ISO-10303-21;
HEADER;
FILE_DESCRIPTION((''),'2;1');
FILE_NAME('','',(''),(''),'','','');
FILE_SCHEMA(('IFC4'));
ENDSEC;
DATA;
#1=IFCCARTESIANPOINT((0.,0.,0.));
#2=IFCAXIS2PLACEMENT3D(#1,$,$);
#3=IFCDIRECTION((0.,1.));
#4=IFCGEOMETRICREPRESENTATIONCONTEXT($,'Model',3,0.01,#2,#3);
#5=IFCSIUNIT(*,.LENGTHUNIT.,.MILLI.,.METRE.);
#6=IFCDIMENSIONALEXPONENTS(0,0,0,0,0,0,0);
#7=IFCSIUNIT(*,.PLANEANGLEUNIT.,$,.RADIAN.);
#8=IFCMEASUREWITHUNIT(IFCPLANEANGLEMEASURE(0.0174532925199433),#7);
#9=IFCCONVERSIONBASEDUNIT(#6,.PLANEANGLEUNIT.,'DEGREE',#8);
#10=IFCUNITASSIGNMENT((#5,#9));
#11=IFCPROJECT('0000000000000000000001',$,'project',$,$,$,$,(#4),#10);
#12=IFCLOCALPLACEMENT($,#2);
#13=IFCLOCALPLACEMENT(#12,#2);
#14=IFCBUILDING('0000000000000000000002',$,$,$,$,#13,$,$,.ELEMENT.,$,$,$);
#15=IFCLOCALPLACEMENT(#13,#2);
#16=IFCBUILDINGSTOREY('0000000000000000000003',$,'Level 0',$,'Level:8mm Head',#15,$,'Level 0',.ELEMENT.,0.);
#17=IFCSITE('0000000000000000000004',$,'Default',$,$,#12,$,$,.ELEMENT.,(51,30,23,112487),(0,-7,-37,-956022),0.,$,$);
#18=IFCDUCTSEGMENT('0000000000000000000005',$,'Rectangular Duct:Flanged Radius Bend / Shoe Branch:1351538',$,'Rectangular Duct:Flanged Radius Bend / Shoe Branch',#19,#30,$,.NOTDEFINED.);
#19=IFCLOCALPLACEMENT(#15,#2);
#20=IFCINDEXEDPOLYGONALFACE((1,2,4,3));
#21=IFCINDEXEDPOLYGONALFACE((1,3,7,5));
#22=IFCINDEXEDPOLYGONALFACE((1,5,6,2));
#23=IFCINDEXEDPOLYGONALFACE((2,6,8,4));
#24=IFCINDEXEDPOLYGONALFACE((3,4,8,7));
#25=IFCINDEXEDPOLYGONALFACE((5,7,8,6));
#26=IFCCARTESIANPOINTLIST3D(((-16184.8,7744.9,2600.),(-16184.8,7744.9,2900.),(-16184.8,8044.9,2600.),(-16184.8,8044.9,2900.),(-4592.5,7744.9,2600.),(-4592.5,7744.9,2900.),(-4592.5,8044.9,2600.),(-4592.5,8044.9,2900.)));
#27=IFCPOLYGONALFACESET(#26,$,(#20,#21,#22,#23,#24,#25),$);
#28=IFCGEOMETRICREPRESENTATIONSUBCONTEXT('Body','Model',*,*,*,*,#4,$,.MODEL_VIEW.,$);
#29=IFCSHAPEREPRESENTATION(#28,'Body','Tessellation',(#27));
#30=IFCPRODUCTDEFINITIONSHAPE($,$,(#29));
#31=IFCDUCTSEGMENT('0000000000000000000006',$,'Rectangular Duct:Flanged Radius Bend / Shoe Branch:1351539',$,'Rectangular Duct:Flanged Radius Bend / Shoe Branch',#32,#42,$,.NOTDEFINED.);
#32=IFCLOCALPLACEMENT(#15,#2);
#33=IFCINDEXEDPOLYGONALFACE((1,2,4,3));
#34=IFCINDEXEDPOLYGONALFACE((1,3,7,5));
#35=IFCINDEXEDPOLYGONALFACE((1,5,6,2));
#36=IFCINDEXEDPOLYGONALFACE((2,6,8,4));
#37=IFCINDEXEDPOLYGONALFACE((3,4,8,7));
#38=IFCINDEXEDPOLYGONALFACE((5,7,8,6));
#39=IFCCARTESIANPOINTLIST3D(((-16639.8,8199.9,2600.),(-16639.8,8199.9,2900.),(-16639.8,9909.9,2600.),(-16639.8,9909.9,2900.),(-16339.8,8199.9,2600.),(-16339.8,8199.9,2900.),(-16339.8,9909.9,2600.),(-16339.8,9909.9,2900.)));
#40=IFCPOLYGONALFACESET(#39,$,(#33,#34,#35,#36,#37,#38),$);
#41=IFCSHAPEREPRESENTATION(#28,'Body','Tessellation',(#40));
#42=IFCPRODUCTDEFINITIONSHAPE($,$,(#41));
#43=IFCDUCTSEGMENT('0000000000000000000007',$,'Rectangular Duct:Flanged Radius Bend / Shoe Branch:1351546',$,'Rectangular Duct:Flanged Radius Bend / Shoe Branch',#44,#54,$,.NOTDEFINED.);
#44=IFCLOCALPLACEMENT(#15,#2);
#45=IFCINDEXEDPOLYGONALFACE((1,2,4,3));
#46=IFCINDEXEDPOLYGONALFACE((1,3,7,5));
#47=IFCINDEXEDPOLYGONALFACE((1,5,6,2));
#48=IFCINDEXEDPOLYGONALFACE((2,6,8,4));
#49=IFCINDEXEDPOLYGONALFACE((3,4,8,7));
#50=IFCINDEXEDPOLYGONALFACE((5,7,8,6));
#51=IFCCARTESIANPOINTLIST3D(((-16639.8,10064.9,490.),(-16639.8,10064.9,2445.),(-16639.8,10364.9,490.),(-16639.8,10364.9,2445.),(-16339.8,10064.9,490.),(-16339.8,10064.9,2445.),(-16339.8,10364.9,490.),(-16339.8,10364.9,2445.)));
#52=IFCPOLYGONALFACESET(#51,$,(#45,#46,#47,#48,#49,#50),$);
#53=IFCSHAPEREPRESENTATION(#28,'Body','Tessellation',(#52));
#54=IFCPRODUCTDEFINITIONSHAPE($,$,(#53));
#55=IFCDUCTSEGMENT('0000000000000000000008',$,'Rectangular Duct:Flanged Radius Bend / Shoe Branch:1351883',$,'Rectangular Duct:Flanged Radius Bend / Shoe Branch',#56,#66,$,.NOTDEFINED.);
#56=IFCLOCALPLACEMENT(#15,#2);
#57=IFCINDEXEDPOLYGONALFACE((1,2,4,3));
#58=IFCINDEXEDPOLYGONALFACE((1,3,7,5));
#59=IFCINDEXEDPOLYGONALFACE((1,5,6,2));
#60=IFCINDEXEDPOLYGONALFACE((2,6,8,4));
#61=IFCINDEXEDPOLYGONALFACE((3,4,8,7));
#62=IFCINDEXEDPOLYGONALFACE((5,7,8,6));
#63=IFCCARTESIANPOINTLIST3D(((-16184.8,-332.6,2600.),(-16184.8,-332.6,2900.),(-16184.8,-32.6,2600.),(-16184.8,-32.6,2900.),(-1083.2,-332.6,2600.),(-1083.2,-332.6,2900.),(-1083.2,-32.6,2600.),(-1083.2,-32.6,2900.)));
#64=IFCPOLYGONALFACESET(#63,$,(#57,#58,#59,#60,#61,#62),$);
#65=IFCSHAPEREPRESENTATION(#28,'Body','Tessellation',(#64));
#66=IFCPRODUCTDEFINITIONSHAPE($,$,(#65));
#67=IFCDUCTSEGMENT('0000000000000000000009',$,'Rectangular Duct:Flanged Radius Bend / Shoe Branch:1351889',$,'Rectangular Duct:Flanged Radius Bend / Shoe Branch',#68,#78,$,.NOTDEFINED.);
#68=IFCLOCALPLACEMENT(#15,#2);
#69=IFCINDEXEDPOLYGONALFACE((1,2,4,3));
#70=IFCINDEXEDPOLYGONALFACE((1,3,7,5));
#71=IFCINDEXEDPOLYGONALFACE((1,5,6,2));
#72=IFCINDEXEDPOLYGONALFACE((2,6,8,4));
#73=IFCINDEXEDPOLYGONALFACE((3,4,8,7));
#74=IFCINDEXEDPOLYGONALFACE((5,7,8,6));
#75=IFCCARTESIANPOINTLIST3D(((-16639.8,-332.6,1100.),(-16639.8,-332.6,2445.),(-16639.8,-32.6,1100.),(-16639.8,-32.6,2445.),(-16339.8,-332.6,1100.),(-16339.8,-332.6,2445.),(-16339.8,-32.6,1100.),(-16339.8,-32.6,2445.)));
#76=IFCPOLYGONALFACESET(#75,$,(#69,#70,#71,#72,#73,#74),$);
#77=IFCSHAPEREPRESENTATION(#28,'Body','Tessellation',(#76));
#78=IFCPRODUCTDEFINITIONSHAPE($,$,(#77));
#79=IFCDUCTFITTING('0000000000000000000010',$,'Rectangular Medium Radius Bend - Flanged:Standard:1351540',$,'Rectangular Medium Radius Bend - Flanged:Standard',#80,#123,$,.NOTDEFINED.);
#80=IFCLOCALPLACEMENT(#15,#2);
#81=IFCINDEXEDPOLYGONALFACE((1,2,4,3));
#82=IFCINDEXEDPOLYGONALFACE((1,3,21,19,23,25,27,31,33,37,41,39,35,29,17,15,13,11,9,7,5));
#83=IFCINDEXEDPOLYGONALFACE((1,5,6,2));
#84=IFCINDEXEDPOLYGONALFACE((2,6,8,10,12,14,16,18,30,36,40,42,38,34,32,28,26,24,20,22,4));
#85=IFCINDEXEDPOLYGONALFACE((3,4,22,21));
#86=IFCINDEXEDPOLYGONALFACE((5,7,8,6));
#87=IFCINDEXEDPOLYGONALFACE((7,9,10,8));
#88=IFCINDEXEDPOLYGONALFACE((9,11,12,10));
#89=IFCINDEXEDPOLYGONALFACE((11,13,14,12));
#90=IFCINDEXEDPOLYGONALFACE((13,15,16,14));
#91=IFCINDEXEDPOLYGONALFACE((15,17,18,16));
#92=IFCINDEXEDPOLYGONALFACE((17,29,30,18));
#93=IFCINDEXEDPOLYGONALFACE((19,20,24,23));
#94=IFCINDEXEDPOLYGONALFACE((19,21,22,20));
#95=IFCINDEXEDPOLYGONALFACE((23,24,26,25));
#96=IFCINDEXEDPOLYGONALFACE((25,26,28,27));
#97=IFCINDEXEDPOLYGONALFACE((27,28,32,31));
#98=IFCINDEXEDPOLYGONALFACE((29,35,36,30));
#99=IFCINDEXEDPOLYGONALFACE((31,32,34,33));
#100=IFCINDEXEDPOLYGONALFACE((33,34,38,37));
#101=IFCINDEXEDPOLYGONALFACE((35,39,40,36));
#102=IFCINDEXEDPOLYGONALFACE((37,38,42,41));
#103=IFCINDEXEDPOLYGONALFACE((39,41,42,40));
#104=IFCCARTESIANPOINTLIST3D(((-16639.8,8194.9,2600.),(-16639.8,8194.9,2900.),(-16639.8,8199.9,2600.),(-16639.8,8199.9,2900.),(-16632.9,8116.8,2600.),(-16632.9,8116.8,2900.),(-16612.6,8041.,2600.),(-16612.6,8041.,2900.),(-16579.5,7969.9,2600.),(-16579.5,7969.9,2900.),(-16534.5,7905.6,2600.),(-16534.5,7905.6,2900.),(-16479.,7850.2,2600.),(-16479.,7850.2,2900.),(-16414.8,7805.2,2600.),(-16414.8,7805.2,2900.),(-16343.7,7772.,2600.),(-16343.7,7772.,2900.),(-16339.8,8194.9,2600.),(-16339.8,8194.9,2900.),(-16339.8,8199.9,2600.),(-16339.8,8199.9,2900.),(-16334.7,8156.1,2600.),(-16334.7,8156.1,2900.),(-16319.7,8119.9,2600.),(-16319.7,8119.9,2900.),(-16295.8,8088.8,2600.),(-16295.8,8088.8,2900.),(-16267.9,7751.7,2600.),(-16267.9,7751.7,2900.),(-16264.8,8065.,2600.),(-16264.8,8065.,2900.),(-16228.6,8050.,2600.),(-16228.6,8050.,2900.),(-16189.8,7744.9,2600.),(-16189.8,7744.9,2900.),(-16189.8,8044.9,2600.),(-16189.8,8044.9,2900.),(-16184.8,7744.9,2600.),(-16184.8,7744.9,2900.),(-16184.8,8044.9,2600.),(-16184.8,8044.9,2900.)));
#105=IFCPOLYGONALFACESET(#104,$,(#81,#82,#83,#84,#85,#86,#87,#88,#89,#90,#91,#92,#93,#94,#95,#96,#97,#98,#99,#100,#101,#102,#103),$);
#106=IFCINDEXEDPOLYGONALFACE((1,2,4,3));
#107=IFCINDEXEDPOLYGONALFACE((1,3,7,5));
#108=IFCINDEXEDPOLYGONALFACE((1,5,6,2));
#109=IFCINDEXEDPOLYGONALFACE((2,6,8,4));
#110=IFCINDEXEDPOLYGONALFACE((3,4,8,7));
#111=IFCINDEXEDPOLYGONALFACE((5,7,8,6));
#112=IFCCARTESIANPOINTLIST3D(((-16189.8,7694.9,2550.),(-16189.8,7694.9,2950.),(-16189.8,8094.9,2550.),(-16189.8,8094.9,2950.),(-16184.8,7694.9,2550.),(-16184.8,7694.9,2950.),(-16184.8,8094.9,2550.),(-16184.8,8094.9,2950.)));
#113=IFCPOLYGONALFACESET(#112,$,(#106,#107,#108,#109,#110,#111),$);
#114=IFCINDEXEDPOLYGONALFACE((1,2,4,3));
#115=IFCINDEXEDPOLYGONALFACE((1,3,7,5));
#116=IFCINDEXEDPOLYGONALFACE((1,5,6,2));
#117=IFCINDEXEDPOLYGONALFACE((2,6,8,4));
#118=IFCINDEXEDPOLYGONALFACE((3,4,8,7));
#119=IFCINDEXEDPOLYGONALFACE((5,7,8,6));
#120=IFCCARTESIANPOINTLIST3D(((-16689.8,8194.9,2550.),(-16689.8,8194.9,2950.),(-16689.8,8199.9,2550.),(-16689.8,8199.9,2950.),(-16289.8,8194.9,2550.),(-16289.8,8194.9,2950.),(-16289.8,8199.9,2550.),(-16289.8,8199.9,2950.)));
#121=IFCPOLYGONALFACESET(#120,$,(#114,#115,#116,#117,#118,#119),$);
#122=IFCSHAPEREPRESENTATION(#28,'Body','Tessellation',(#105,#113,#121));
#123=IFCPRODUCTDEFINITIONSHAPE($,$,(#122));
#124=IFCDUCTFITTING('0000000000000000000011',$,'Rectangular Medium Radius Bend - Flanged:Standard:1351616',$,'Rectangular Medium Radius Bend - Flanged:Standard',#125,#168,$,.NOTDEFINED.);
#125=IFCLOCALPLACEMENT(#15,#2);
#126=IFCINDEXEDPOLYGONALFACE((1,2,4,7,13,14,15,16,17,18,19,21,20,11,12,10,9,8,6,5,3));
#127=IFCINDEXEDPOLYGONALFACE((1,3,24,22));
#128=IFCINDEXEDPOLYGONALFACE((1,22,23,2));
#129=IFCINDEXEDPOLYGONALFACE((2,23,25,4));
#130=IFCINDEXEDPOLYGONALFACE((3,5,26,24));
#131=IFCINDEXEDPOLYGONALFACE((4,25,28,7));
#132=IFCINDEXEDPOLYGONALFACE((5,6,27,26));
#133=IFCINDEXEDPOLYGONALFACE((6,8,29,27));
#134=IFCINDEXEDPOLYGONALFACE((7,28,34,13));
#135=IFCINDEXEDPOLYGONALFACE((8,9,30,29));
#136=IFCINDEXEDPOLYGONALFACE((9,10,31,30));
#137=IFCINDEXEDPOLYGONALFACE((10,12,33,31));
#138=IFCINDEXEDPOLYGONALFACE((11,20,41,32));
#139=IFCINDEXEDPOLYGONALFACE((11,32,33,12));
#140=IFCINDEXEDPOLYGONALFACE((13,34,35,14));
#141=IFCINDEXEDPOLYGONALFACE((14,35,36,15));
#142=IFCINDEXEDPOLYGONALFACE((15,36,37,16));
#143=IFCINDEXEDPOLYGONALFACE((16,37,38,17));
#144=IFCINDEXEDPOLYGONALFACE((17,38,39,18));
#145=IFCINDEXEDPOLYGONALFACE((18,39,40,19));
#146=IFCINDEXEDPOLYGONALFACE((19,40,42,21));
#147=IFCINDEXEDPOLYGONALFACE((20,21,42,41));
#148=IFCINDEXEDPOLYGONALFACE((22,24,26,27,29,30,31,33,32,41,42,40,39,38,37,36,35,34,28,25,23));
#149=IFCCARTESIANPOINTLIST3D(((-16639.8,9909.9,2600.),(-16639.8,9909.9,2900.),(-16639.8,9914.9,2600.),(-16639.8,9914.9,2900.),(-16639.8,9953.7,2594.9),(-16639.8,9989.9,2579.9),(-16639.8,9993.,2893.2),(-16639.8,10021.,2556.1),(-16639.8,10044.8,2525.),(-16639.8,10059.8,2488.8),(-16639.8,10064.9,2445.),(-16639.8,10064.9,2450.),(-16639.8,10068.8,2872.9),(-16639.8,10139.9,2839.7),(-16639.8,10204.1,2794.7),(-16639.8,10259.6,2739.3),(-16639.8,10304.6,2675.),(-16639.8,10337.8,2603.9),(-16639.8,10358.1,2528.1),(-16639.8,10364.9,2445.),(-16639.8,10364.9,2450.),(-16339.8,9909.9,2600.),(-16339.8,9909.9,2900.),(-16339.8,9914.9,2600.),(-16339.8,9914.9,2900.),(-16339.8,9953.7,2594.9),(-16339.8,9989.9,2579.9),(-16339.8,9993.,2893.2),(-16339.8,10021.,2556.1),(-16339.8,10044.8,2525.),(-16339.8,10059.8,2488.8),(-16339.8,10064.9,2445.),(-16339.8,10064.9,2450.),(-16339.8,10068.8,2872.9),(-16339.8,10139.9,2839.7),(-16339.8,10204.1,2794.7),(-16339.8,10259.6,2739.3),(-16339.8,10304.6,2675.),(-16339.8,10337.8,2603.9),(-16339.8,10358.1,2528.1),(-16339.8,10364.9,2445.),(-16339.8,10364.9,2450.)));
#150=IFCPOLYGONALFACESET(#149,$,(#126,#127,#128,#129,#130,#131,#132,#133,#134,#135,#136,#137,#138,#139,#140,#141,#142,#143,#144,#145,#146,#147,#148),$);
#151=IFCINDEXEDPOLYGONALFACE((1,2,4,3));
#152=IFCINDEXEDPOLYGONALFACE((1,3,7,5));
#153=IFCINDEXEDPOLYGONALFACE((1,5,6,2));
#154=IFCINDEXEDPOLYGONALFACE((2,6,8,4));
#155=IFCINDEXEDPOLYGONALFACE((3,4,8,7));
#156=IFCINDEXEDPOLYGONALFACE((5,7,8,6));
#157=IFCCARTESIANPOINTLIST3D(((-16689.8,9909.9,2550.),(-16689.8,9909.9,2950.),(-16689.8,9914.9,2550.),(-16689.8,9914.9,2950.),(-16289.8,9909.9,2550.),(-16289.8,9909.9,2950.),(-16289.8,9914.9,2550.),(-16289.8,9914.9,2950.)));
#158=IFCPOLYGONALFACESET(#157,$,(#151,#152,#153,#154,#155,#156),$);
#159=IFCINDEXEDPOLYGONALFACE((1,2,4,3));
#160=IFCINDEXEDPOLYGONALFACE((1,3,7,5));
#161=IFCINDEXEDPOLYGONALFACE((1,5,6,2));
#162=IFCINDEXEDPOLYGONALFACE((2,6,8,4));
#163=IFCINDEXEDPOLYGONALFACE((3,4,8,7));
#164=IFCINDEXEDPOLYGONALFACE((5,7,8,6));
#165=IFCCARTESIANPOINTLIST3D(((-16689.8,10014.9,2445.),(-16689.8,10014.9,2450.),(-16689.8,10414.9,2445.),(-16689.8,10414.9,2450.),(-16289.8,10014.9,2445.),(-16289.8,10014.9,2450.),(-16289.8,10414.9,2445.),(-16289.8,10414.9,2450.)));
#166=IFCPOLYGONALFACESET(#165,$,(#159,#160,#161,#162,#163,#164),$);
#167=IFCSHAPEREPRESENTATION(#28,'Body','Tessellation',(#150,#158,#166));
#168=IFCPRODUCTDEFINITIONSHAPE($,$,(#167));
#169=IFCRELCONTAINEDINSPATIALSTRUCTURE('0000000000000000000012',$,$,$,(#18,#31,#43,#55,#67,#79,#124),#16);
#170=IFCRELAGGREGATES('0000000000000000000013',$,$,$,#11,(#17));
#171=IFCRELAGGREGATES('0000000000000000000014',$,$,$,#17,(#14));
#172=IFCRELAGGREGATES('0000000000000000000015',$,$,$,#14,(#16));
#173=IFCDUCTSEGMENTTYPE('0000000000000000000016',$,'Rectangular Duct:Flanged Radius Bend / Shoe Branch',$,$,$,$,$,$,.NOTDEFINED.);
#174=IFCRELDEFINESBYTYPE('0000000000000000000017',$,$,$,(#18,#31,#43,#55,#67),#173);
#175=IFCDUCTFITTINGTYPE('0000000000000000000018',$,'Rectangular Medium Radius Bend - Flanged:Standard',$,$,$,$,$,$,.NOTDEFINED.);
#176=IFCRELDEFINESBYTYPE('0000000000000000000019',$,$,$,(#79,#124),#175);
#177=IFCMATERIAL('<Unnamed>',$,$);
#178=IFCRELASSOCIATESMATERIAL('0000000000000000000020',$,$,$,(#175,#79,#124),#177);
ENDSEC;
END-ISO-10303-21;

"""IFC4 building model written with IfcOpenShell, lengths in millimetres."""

from ifc_helpers import new_model, entity, si_unit, converted_unit, direction, frame, origin, place, context, subcontext, project, spatial, line, arc, indexed_curve, outline, extrude, source, transform, mapped, material, type_object, type_shapes, element, save


model = new_model("IFC4")

# Units and contexts
model_context = context("Model", 3, precision=0.01, world=origin(), true_north=direction((0.0, 1.0)))
body_context = subcontext(model_context, "Body", "Model", "MODEL_VIEW")
ifc_project = project(units=[si_unit("LENGTHUNIT", "METRE", prefix="MILLI"), converted_unit("PLANEANGLEUNIT", "DEGREE", entity("IfcPlaneAngleMeasure", 0.0174532925199433), si_unit("PLANEANGLEUNIT", "RADIAN"), dimensions=[0, 0, 0, 0, 0, 0, 0])], contexts=[model_context])

# Site, building, storey
site_placement = place(None, origin())
site = spatial("IfcSite", under=ifc_project, at=site_placement, Name="Default", CompositionType="ELEMENT", RefLatitude=(51, 30, 23, 112487), RefLongitude=(0, -7, -37, -956022), RefElevation=0.0)
building_placement = place(site_placement, origin())
building = spatial("IfcBuilding", under=site, at=building_placement, CompositionType="ELEMENT")
storey_placement = place(building_placement, origin())
storey = spatial("IfcBuildingStorey", under=building, at=storey_placement, Name="Level 0", ObjectType="Level:8mm Head", LongName="Level 0", CompositionType="ELEMENT", Elevation=0.0)

# Duct segments
duct_segment_type_1 = type_object("IfcDuctSegmentType", Name="Rectangular Duct:Flanged Radius Bend / Shoe Branch", PredefinedType="NOTDEFINED")
duct_segment_1_placement = place(storey_placement, origin())
element("IfcDuctSegment", 1, at=duct_segment_1_placement, inside=storey, type_object=duct_segment_type_1, Name="Rectangular Duct:Flanged Radius Bend / Shoe Branch:1351538", ObjectType="Rectangular Duct:Flanged Radius Bend / Shoe Branch", PredefinedType="NOTDEFINED", context=body_context, shape_type="SweptSolid", body=[
    extrude(outline(indexed_curve([(-5796.1, -150.0), (5796.1, -150.0), (5796.1, 150.0), (-5796.1, 150.0), (-5796.1, -150.0)], self_intersect=False)), frame((-10388.6, 7894.9, 2600.0), z_axis=(0.0, 0.0, 1.0), x_axis=(-1.0, 0.0, 0.0)), (0.0, 0.0, 1.0), 300.0),
])
duct_segment_2_placement = place(storey_placement, origin())
element("IfcDuctSegment", 2, at=duct_segment_2_placement, inside=storey, type_object=duct_segment_type_1, Name="Rectangular Duct:Flanged Radius Bend / Shoe Branch:1351539", ObjectType="Rectangular Duct:Flanged Radius Bend / Shoe Branch", PredefinedType="NOTDEFINED", context=body_context, shape_type="SweptSolid", body=[
    extrude(outline(indexed_curve([(-855.0, -150.0), (855.0, -150.0), (855.0, 150.0), (-855.0, 150.0), (-855.0, -150.0)], self_intersect=False)), frame((-16489.8, 9054.9, 2600.0), z_axis=(0.0, 0.0, 1.0), x_axis=(0.0, -1.0, 0.0)), (0.0, 0.0, 1.0), 300.0),
])
duct_segment_3_placement = place(storey_placement, origin())
element("IfcDuctSegment", 3, at=duct_segment_3_placement, inside=storey, type_object=duct_segment_type_1, Name="Rectangular Duct:Flanged Radius Bend / Shoe Branch:1351546", ObjectType="Rectangular Duct:Flanged Radius Bend / Shoe Branch", PredefinedType="NOTDEFINED", context=body_context, shape_type="SweptSolid", body=[
    extrude(outline(indexed_curve([(-150.0, -150.0), (150.0, -150.0), (150.0, 150.0), (-150.0, 150.0), (-150.0, -150.0)], self_intersect=False)), frame((-16489.8, 10214.9, 490.0), z_axis=(0.0, 0.0, 1.0), x_axis=(0.0, 1.0, 0.0)), (0.0, 0.0, 1.0), 1955.0),
])
duct_segment_4_placement = place(storey_placement, origin())
element("IfcDuctSegment", 4, at=duct_segment_4_placement, inside=storey, type_object=duct_segment_type_1, Name="Rectangular Duct:Flanged Radius Bend / Shoe Branch:1351883", ObjectType="Rectangular Duct:Flanged Radius Bend / Shoe Branch", PredefinedType="NOTDEFINED", context=body_context, shape_type="SweptSolid", body=[
    extrude(outline(indexed_curve([(-7550.8, -150.0), (7550.8, -150.0), (7550.8, 150.0), (-7550.8, 150.0), (-7550.8, -150.0)], self_intersect=False)), frame((-8634.0, -182.6, 2600.0)), (0.0, 0.0, 1.0), 300.0),
])
duct_segment_5_placement = place(storey_placement, origin())
element("IfcDuctSegment", 5, at=duct_segment_5_placement, inside=storey, type_object=duct_segment_type_1, Name="Rectangular Duct:Flanged Radius Bend / Shoe Branch:1351889", ObjectType="Rectangular Duct:Flanged Radius Bend / Shoe Branch", PredefinedType="NOTDEFINED", context=body_context, shape_type="SweptSolid", body=[
    extrude(outline(indexed_curve([(-150.0, -150.0), (150.0, -150.0), (150.0, 150.0), (-150.0, 150.0), (-150.0, -150.0)], self_intersect=False)), frame((-16489.8, -182.6, 1100.0), z_axis=(0.0, 0.0, 1.0), x_axis=(0.0, 1.0, 0.0)), (0.0, 0.0, 1.0), 1345.0),
])

# Duct fittings
ifc_material = material(Name="<Unnamed>")
duct_fitting_type = type_object("IfcDuctFittingType", Name="Rectangular Medium Radius Bend - Flanged:Standard", PredefinedType="NOTDEFINED", material=ifc_material)
shared_shape = source(origin(), body_context, "Body", "SweptSolid", [
    extrude(outline(indexed_curve([(-153.8, -301.2), (-148.7, -301.2), (169.4, -169.4), (301.3, 148.7), (301.3, 153.7), (1.3, 153.8), (1.3, 148.8), (-42.7, 42.7), (-148.7, -1.2), (-153.8, -1.2)], segments=[line(1, 2), arc(2, 3, 4), line(4, 5, 6, 7), arc(7, 8, 9), line(9, 10, 1)], self_intersect=False)), frame((-151.2, 151.2, -150.0)), (0.0, 0.0, 1.0), 300.0),
    extrude(outline(indexed_curve([(-2.5, -200.0), (2.5, -200.0), (2.5, 200.0), (-2.5, 200.0), (-2.5, -200.0)], self_intersect=False)), frame((0.0, 302.5, -200.0), z_axis=(0.0, 0.0, 1.0), x_axis=(0.0, 1.0, 0.0)), (0.0, 0.0, 1.0), 400.0),
    extrude(outline(indexed_curve([(-2.5, -200.0), (2.5, -200.0), (2.5, 200.0), (-2.5, 200.0), (-2.5, -200.0)], self_intersect=False)), frame((-302.5, 0.0, -200.0)), (0.0, 0.0, 1.0), 400.0),
])
type_shapes(duct_fitting_type, [shared_shape])
for number, where, z_axis, x_axis, name in (
    (6, (-16489.8, 7894.9, 2750.0), (0.0, 0.0, 1.0), (0.0, -1.0, 0.0), "Rectangular Medium Radius Bend - Flanged:Standard:1351540"),
    (7, (-16489.8, 10214.9, 2750.0), (1.0, 0.0, 0.0), (0.0, 0.0, 1.0), "Rectangular Medium Radius Bend - Flanged:Standard:1351616"),
):
    element("IfcDuctFitting", number, at=place(storey_placement, frame(where, z_axis=z_axis, x_axis=x_axis)), inside=storey, type_object=duct_fitting_type, material=ifc_material, Name=name, ObjectType="Rectangular Medium Radius Bend - Flanged:Standard", PredefinedType="NOTDEFINED", context=body_context, shape_type="MappedRepresentation", body=[
        mapped(shared_shape, transform((0.0, 0.0, 0.0), scale=1.0)),
    ])

save(model, "model.ifc")
